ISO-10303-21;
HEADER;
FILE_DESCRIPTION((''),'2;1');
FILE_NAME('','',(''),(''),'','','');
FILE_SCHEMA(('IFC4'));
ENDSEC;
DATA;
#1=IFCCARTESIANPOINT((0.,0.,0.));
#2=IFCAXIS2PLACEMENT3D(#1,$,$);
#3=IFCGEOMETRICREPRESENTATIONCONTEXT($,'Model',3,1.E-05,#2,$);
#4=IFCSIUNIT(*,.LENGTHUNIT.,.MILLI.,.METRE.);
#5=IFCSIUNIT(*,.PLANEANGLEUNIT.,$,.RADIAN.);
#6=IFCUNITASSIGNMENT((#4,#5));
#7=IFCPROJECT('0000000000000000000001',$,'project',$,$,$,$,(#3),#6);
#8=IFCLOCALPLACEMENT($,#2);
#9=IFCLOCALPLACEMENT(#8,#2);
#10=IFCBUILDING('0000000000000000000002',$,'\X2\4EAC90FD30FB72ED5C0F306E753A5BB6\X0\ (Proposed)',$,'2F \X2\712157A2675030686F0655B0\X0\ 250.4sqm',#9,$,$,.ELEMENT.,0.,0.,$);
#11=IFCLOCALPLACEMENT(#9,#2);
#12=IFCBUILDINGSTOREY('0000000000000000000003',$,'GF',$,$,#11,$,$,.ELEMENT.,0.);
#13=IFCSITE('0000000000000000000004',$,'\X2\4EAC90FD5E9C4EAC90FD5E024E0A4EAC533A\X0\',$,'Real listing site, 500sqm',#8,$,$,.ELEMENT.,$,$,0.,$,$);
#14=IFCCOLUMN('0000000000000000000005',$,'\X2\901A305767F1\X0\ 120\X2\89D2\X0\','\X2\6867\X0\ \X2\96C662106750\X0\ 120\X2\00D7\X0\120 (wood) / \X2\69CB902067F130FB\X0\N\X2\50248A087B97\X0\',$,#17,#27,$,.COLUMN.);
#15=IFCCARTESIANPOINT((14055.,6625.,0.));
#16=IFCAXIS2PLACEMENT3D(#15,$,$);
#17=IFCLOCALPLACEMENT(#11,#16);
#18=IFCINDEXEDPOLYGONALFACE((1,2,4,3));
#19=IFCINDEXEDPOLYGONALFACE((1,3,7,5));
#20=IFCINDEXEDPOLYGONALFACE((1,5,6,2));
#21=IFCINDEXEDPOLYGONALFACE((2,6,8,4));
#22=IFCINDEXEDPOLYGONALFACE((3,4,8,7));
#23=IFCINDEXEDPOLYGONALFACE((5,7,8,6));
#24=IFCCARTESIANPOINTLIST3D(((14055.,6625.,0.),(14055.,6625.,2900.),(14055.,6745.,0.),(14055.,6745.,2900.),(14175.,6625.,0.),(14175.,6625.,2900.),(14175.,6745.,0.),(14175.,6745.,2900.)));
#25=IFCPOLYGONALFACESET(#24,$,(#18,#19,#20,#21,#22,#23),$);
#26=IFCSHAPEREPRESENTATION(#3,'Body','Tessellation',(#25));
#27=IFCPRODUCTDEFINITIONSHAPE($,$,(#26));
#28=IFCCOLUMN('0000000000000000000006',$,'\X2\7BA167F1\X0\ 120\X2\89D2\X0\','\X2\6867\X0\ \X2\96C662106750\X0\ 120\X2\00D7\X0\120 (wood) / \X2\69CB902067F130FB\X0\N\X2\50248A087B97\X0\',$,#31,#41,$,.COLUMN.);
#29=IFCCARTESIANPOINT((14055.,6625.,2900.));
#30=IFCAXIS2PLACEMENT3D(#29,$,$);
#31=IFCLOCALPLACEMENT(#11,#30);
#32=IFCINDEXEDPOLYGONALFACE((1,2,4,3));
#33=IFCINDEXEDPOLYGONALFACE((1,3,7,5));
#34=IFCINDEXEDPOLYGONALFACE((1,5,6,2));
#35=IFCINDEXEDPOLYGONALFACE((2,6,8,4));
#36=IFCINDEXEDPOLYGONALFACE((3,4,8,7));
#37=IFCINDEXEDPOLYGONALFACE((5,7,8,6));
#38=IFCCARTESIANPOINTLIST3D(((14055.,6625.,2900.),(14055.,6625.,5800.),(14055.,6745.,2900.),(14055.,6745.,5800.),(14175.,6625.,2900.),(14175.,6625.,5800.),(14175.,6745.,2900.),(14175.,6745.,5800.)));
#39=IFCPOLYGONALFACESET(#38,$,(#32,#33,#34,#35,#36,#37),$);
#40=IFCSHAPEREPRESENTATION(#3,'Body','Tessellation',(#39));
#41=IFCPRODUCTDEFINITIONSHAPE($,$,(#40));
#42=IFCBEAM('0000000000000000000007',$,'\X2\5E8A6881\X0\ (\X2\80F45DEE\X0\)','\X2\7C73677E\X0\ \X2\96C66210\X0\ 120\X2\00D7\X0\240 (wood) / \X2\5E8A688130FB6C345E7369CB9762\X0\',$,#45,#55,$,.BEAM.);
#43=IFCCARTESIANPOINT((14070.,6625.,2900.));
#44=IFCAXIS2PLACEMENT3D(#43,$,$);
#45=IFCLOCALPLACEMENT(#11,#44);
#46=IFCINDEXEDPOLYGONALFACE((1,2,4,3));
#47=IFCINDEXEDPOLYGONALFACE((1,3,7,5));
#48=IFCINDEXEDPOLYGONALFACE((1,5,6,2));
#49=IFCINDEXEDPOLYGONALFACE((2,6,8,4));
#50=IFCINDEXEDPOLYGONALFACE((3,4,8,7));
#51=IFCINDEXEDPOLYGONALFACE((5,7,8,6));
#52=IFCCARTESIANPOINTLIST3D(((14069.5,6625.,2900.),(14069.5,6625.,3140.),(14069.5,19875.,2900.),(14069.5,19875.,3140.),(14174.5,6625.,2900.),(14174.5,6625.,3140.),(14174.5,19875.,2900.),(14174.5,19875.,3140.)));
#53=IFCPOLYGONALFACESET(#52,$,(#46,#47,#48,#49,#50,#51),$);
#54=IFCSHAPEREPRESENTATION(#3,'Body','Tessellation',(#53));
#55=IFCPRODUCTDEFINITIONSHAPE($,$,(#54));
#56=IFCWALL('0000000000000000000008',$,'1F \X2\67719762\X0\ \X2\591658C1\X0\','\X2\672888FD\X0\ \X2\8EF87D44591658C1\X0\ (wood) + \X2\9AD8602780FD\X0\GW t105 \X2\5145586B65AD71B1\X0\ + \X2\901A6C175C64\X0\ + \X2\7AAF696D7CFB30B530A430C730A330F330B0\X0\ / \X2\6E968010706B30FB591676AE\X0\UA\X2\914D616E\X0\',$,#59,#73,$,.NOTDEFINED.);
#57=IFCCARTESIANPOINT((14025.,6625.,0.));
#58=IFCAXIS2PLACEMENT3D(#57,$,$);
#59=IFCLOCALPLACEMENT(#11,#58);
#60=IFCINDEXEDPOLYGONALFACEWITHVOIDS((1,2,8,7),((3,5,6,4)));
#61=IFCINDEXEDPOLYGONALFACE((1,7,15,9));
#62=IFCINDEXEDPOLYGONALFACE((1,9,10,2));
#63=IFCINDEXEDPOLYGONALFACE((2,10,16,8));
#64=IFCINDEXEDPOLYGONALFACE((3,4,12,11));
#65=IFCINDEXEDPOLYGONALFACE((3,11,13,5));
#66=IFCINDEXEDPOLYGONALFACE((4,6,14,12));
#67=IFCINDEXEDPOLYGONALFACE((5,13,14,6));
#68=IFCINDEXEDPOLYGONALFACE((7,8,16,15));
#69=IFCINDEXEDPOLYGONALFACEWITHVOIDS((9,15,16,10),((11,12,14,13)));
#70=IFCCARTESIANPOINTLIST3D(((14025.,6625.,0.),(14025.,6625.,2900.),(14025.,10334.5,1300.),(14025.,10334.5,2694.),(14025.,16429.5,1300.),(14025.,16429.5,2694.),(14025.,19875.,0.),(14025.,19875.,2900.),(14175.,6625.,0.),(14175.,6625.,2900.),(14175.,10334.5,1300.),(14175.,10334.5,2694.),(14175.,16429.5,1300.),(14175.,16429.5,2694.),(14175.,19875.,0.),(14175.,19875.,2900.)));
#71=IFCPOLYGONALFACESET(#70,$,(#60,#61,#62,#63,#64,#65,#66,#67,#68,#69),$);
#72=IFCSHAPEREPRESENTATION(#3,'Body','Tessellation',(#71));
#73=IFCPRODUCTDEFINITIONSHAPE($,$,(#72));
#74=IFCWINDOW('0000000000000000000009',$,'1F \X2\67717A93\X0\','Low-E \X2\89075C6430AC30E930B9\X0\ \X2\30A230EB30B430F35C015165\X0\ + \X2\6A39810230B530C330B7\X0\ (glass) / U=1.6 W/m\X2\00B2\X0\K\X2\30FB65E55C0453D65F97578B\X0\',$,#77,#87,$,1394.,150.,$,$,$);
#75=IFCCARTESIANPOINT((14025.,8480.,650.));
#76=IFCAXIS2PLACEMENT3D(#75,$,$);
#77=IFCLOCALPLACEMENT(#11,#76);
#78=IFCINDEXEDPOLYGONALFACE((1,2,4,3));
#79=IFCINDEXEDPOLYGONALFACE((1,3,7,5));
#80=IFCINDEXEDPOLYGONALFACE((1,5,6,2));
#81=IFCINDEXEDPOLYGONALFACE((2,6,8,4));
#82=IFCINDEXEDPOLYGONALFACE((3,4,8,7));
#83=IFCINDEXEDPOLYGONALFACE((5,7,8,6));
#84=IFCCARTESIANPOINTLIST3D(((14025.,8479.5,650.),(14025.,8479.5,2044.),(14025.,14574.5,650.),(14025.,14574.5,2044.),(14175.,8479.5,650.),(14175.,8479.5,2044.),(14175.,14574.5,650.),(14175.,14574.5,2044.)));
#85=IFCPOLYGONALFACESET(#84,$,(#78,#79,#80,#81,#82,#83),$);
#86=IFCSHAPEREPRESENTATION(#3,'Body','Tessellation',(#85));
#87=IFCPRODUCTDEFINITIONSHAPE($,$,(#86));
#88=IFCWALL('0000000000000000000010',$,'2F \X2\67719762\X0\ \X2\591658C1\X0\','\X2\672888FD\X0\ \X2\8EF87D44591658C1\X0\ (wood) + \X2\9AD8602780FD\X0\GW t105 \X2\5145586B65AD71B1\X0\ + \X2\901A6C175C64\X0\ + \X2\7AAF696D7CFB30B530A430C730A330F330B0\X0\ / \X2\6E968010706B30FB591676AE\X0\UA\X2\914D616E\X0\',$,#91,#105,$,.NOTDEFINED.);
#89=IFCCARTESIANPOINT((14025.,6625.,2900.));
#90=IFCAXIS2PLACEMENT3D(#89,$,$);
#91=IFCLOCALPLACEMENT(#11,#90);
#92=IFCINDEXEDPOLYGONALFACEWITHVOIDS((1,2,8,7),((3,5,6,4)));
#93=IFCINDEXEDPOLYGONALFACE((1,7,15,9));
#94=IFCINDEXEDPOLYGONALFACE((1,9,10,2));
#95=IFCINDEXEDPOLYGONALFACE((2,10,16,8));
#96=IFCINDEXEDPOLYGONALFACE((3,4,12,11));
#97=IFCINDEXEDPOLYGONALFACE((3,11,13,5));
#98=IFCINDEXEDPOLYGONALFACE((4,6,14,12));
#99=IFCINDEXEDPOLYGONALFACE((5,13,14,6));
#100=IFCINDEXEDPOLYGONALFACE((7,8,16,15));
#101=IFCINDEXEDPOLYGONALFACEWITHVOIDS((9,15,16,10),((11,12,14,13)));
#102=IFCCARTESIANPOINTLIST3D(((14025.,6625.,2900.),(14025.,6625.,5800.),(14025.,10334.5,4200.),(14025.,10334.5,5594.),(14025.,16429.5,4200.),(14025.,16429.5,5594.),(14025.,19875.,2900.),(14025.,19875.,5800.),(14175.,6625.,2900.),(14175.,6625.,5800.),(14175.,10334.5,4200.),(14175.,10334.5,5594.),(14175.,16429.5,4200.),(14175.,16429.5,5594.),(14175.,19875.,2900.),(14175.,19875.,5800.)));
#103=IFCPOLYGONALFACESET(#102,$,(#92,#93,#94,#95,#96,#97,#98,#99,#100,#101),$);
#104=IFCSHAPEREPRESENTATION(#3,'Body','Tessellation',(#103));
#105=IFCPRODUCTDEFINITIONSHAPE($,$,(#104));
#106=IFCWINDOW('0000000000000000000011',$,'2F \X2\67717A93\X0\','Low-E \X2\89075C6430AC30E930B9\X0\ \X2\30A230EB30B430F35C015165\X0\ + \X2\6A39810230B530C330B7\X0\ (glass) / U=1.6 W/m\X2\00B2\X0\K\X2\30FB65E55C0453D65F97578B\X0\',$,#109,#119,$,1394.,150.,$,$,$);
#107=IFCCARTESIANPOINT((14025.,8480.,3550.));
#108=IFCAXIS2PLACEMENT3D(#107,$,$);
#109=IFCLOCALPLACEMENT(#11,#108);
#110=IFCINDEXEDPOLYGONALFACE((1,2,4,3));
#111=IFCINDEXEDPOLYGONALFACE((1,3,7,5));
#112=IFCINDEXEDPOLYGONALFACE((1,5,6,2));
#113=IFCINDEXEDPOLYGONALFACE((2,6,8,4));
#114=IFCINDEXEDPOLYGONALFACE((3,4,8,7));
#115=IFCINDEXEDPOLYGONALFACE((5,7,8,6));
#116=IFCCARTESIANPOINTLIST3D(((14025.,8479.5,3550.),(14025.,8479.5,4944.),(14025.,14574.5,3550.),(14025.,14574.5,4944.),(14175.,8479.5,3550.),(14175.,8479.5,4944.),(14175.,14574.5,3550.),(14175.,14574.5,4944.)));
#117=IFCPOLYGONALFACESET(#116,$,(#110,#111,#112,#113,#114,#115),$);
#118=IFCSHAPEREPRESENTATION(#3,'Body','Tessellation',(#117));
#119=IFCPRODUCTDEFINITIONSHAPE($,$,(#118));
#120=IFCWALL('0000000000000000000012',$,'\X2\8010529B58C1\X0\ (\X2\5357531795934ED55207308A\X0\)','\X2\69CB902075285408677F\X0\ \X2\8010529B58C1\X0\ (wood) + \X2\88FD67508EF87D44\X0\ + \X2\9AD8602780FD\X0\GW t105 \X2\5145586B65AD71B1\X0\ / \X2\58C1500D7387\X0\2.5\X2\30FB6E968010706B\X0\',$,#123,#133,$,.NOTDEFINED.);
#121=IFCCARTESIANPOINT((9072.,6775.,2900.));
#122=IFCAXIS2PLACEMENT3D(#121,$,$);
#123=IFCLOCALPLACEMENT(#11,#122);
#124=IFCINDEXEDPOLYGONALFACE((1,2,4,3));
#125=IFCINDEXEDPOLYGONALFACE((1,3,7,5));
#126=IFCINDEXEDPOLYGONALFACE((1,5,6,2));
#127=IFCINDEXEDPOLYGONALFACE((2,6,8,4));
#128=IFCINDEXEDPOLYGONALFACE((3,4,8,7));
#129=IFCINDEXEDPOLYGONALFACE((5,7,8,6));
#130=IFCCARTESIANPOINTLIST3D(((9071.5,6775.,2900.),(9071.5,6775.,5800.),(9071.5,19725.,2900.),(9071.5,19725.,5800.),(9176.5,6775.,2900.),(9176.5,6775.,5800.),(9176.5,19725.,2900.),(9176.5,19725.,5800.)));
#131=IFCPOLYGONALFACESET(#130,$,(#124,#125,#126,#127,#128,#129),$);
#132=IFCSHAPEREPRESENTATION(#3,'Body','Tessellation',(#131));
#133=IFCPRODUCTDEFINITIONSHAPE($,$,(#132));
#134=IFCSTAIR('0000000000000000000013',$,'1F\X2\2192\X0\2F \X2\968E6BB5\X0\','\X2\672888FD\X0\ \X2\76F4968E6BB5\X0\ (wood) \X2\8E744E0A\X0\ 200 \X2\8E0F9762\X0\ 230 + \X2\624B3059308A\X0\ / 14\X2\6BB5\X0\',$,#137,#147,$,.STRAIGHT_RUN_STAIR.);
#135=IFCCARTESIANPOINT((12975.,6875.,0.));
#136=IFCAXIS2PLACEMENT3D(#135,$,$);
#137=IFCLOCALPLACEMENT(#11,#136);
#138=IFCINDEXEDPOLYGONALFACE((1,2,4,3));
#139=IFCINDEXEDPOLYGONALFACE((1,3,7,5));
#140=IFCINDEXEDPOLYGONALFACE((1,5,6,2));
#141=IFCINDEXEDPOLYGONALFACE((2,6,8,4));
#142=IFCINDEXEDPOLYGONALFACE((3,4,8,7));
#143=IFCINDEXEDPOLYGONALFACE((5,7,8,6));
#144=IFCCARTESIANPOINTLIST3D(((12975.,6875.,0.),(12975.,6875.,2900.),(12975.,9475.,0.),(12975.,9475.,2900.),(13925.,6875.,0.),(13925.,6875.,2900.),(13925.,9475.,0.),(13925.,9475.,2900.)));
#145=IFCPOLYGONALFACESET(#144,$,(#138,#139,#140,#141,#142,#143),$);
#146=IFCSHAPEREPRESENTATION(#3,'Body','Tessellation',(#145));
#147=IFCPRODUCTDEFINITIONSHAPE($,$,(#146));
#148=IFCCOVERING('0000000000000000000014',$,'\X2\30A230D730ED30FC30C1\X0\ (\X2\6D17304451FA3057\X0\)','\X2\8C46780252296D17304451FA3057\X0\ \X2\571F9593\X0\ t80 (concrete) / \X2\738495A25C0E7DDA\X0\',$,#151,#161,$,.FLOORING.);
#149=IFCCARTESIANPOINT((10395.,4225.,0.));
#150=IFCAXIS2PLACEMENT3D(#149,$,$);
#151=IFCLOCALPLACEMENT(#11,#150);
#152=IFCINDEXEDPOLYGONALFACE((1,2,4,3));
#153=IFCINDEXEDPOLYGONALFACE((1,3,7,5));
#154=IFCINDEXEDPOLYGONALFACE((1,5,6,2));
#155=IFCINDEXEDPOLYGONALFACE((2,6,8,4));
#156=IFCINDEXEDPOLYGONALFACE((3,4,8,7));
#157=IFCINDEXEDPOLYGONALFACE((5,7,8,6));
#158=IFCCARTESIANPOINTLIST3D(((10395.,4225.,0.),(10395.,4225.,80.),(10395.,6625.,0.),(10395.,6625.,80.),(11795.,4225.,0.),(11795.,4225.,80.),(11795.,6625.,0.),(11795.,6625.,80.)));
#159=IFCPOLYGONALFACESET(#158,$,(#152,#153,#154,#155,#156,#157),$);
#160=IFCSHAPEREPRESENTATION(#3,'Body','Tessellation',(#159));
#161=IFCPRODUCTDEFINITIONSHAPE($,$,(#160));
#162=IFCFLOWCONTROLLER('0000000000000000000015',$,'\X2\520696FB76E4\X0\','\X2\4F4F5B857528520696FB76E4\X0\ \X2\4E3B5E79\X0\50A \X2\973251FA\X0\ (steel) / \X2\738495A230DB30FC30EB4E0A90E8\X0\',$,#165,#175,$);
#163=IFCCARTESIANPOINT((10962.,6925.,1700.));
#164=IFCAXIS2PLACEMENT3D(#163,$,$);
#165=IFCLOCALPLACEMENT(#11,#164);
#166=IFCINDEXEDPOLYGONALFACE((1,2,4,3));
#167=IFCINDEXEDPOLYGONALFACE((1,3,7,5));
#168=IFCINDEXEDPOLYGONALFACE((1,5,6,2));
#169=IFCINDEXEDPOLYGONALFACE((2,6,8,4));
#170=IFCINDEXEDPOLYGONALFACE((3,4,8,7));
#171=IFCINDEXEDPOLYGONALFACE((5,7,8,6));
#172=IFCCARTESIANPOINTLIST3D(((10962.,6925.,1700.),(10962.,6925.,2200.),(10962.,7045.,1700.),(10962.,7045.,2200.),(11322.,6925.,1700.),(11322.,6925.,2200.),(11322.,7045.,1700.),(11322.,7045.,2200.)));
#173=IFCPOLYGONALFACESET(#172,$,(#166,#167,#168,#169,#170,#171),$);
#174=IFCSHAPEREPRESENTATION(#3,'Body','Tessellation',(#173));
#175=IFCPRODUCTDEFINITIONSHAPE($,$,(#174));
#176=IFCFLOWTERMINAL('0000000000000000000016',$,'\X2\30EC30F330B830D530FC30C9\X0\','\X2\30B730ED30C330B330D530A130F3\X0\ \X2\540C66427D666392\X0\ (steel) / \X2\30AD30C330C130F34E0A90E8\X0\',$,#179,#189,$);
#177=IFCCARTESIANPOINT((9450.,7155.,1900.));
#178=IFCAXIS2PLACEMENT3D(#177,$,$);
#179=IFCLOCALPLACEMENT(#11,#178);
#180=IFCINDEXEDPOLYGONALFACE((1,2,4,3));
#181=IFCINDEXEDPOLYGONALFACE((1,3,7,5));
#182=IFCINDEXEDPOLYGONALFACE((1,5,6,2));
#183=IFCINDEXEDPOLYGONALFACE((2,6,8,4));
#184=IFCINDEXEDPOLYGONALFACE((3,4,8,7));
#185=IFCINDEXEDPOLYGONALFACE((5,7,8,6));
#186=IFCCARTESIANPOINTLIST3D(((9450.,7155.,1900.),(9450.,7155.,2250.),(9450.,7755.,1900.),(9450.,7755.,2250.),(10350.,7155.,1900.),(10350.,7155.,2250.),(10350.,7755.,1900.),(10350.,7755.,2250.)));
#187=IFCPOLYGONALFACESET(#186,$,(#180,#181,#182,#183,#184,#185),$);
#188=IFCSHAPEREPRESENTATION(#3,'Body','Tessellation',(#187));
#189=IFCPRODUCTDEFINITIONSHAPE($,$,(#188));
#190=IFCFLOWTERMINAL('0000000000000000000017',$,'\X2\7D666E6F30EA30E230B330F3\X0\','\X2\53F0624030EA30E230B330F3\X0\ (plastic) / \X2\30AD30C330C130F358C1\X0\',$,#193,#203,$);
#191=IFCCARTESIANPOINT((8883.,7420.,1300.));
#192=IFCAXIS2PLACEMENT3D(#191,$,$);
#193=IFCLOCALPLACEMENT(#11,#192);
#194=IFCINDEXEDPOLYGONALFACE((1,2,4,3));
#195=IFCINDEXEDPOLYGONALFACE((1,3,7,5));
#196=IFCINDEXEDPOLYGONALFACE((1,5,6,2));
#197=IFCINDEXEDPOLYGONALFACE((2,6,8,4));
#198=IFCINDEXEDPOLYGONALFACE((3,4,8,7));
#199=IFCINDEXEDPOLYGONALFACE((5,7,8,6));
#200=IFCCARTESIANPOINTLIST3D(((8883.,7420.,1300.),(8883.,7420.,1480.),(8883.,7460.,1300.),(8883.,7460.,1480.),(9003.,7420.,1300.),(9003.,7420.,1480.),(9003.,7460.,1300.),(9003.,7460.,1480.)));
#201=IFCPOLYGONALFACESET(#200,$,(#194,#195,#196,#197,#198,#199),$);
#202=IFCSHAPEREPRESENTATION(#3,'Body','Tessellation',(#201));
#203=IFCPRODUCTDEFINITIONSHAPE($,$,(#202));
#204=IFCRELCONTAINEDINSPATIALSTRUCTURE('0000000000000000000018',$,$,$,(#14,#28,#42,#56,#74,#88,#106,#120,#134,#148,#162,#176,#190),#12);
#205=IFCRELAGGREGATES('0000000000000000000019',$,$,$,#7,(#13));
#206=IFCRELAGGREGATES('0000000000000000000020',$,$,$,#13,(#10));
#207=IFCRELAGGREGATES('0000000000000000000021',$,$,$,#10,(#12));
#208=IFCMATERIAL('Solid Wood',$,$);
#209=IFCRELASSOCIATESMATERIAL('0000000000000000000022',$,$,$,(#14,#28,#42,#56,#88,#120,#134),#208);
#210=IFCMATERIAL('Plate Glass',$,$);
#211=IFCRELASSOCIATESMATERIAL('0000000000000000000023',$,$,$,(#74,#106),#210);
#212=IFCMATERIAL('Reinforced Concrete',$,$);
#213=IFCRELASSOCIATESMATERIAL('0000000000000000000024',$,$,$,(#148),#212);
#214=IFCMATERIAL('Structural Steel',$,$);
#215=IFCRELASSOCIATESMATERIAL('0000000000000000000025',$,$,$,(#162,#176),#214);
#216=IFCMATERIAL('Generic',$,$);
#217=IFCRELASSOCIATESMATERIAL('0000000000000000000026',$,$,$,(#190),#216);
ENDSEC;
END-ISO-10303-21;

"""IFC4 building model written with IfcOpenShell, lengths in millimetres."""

from ifc_helpers import new_model, si_unit, frame, frame_2d, origin, place, context, project, spatial, rectangle, extrude, material, element, fill, save


model = new_model("IFC4")

# Units and contexts
model_context = context("Model", 3, precision=1e-05, world=origin())
ifc_project = project(units=[si_unit("LENGTHUNIT", "METRE", prefix="MILLI"), si_unit("PLANEANGLEUNIT", "RADIAN")], contexts=[model_context])

# Site, building, storey
site_placement = place(None, origin())
site = spatial("IfcSite", under=ifc_project, at=site_placement, Name="京都府京都市上京区", ObjectType="Real listing site, 500sqm", CompositionType="ELEMENT", RefElevation=0.0)
building_placement = place(site_placement, origin())
building = spatial("IfcBuilding", under=site, at=building_placement, Name="京都・狭小の町家 (Proposed)", ObjectType="2F 無垢材と漆喰 250.4sqm", CompositionType="ELEMENT", ElevationOfRefHeight=0.0, ElevationOfTerrain=0.0)
storey_placement = place(building_placement, origin())
storey = spatial("IfcBuildingStorey", under=building, at=storey_placement, Name="GF", CompositionType="ELEMENT", Elevation=0.0)

# Columns
ifc_material_1 = material(Name="Solid Wood")
column_1_placement = place(storey_placement, frame((14055.0, 6625.0, 0.0)))
element("IfcColumn", 1, at=column_1_placement, inside=storey, material=ifc_material_1, Name="通し柱 120角", Description="桧 集成材 120×120 (wood) / 構造柱・N値計算", PredefinedType="COLUMN", context=model_context, shape_type="SweptSolid", body=[
    extrude(rectangle(XDim=120.0, YDim=120.0, at=frame_2d((60.0, 60.0))), frame((14055.0, 6625.0, 0.0)), (0.0, 0.0, 1.0), 2900.0),
])
column_2_placement = place(storey_placement, frame((14055.0, 6625.0, 2900.0)))
element("IfcColumn", 2, at=column_2_placement, inside=storey, material=ifc_material_1, Name="管柱 120角", Description="桧 集成材 120×120 (wood) / 構造柱・N値計算", PredefinedType="COLUMN", context=model_context, shape_type="SweptSolid", body=[
    extrude(rectangle(XDim=120.0, YDim=120.0, at=frame_2d((60.0, 60.0))), frame((14055.0, 6625.0, 2900.0)), (0.0, 0.0, 1.0), 2900.0),
])

# Beam
beam_1_placement = place(storey_placement, frame((14070.0, 6625.0, 2900.0)))
element("IfcBeam", 3, at=beam_1_placement, inside=storey, material=ifc_material_1, Name="床梁 (胴差)", Description="米松 集成 120×240 (wood) / 床梁・水平構面", PredefinedType="BEAM", context=model_context, shape_type="SweptSolid", body=[
    extrude(rectangle(XDim=105.0, YDim=13250.0, at=frame_2d((52.0, 6625.0))), frame((14070.0, 6625.0, 2900.0)), (0.0, 0.0, 1.0), 240.0),
])

# Wall, opening, window
wall_1_placement = place(storey_placement, frame((14025.0, 6625.0, 0.0)))
wall_1 = element("IfcWall", 4, at=wall_1_placement, inside=storey, material=ifc_material_1, Name="1F 東面 外壁", Description="木製 軸組外壁 (wood) + 高性能GW t105 充填断熱 + 通気層 + 窯業系サイディング / 準耐火・外皮UA配慮", PredefinedType="NOTDEFINED", context=model_context, shape_type="SweptSolid", body=[
    extrude(rectangle(XDim=150.0, YDim=13250.0, at=frame_2d((75.0, 6625.0))), frame((14025.0, 6625.0, 0.0)), (0.0, 0.0, 1.0), 2900.0),
])
opening_1_placement = place(storey_placement, frame((14025.0, 8480.0, 650.0)))
opening_1 = element("IfcOpeningElement", 5, at=opening_1_placement, cuts=wall_1, PredefinedType="NOTDEFINED", context=model_context, shape_type="SweptSolid", body=[
    extrude(rectangle(XDim=150.0, YDim=6095.0, at=frame_2d((75.0, 3047.0))), frame((14025.0, 8480.0, 650.0)), (0.0, 0.0, 1.0), 1394.0),
])
ifc_material_2 = material(Name="Plate Glass")
window_1_placement = place(storey_placement, frame((14025.0, 8480.0, 650.0)))
window_1 = element("IfcWindow", 6, at=window_1_placement, inside=storey, material=ifc_material_2, Name="1F 東窓", Description="Low-E 複層ガラス アルゴン封入 + 樹脂サッシ (glass) / U=1.6 W/m²K・日射取得型", OverallHeight=1394.0, OverallWidth=150.0, context=model_context, shape_type="SweptSolid", body=[
    extrude(rectangle(XDim=150.0, YDim=6095.0, at=frame_2d((75.0, 3047.0))), frame((14025.0, 8480.0, 650.0)), (0.0, 0.0, 1.0), 1394.0),
])
fill(opening_1, window_1)

# Wall, opening, window
wall_2_placement = place(storey_placement, frame((14025.0, 6625.0, 2900.0)))
wall_2 = element("IfcWall", 7, at=wall_2_placement, inside=storey, material=ifc_material_1, Name="2F 東面 外壁", Description="木製 軸組外壁 (wood) + 高性能GW t105 充填断熱 + 通気層 + 窯業系サイディング / 準耐火・外皮UA配慮", PredefinedType="NOTDEFINED", context=model_context, shape_type="SweptSolid", body=[
    extrude(rectangle(XDim=150.0, YDim=13250.0, at=frame_2d((75.0, 6625.0))), frame((14025.0, 6625.0, 2900.0)), (0.0, 0.0, 1.0), 2900.0),
])
opening_2_placement = place(storey_placement, frame((14025.0, 8480.0, 3550.0)))
opening_2 = element("IfcOpeningElement", 8, at=opening_2_placement, cuts=wall_2, PredefinedType="NOTDEFINED", context=model_context, shape_type="SweptSolid", body=[
    extrude(rectangle(XDim=150.0, YDim=6095.0, at=frame_2d((75.0, 3047.0))), frame((14025.0, 8480.0, 3550.0)), (0.0, 0.0, 1.0), 1394.0),
])
window_2_placement = place(storey_placement, frame((14025.0, 8480.0, 3550.0)))
window_2 = element("IfcWindow", 9, at=window_2_placement, inside=storey, material=ifc_material_2, Name="2F 東窓", Description="Low-E 複層ガラス アルゴン封入 + 樹脂サッシ (glass) / U=1.6 W/m²K・日射取得型", OverallHeight=1394.0, OverallWidth=150.0, context=model_context, shape_type="SweptSolid", body=[
    extrude(rectangle(XDim=150.0, YDim=6095.0, at=frame_2d((75.0, 3047.0))), frame((14025.0, 8480.0, 3550.0)), (0.0, 0.0, 1.0), 1394.0),
])
fill(opening_2, window_2)

# Wall
wall_3_placement = place(storey_placement, frame((9072.0, 6775.0, 2900.0)))
element("IfcWall", 10, at=wall_3_placement, inside=storey, material=ifc_material_1, Name="耐力壁 (南北間仕切り)", Description="構造用合板 耐力壁 (wood) + 製材軸組 + 高性能GW t105 充填断熱 / 壁倍率2.5・準耐火", PredefinedType="NOTDEFINED", context=model_context, shape_type="SweptSolid", body=[
    extrude(rectangle(XDim=105.0, YDim=12950.0, at=frame_2d((52.0, 6475.0))), frame((9072.0, 6775.0, 2900.0)), (0.0, 0.0, 1.0), 2900.0),
])

# Stair
stair_placement = place(storey_placement, frame((12975.0, 6875.0, 0.0)))
element("IfcStair", 11, at=stair_placement, inside=storey, material=ifc_material_1, Name="1F→2F 階段", Description="木製 直階段 (wood) 蹴上 200 踏面 230 + 手すり / 14段", PredefinedType="STRAIGHT_RUN_STAIR", context=model_context, shape_type="SweptSolid", body=[
    extrude(rectangle(XDim=950.0, YDim=2600.0, at=frame_2d((475.0, 1300.0))), frame((12975.0, 6875.0, 0.0)), (0.0, 0.0, 1.0), 2900.0),
])

# Covering
ifc_material_3 = material(Name="Reinforced Concrete")
covering_placement = place(storey_placement, frame((10395.0, 4225.0, 0.0)))
element("IfcCovering", 12, at=covering_placement, inside=storey, material=ifc_material_3, Name="アプローチ (洗い出し)", Description="豆砂利洗い出し 土間 t80 (concrete) / 玄関導線", PredefinedType="FLOORING", context=model_context, shape_type="SweptSolid", body=[
    extrude(rectangle(XDim=1400.0, YDim=2400.0, at=frame_2d((700.0, 1200.0))), frame((10395.0, 4225.0, 0.0)), (0.0, 0.0, 1.0), 80.0),
])

# Flow controller
ifc_material_4 = material(Name="Structural Steel")
flow_controller_placement = place(storey_placement, frame((10962.0, 6925.0, 1700.0)))
element("IfcFlowController", 13, at=flow_controller_placement, inside=storey, material=ifc_material_4, Name="分電盤", Description="住宅用分電盤 主幹50A 露出 (steel) / 玄関ホール上部", context=model_context, shape_type="SweptSolid", body=[
    extrude(rectangle(XDim=360.0, YDim=120.0, at=frame_2d((180.0, 60.0))), frame((10962.0, 6925.0, 1700.0)), (0.0, 0.0, 1.0), 500.0),
])

# Flow terminals
flow_terminal_1_placement = place(storey_placement, frame((9450.0, 7155.0, 1900.0)))
element("IfcFlowTerminal", 14, at=flow_terminal_1_placement, inside=storey, material=ifc_material_4, Name="レンジフード", Description="シロッコファン 同時給排 (steel) / キッチン上部", context=model_context, shape_type="SweptSolid", body=[
    extrude(rectangle(XDim=900.0, YDim=600.0, at=frame_2d((450.0, 300.0))), frame((9450.0, 7155.0, 1900.0)), (0.0, 0.0, 1.0), 350.0),
])
ifc_material_5 = material(Name="Generic")
flow_terminal_2_placement = place(storey_placement, frame((8883.0, 7420.0, 1300.0)))
element("IfcFlowTerminal", 15, at=flow_terminal_2_placement, inside=storey, material=ifc_material_5, Name="給湯リモコン", Description="台所リモコン (plastic) / キッチン壁", context=model_context, shape_type="SweptSolid", body=[
    extrude(rectangle(XDim=120.0, YDim=40.0, at=frame_2d((60.0, 20.0))), frame((8883.0, 7420.0, 1300.0)), (0.0, 0.0, 1.0), 180.0),
])

save(model, "model.ifc")
